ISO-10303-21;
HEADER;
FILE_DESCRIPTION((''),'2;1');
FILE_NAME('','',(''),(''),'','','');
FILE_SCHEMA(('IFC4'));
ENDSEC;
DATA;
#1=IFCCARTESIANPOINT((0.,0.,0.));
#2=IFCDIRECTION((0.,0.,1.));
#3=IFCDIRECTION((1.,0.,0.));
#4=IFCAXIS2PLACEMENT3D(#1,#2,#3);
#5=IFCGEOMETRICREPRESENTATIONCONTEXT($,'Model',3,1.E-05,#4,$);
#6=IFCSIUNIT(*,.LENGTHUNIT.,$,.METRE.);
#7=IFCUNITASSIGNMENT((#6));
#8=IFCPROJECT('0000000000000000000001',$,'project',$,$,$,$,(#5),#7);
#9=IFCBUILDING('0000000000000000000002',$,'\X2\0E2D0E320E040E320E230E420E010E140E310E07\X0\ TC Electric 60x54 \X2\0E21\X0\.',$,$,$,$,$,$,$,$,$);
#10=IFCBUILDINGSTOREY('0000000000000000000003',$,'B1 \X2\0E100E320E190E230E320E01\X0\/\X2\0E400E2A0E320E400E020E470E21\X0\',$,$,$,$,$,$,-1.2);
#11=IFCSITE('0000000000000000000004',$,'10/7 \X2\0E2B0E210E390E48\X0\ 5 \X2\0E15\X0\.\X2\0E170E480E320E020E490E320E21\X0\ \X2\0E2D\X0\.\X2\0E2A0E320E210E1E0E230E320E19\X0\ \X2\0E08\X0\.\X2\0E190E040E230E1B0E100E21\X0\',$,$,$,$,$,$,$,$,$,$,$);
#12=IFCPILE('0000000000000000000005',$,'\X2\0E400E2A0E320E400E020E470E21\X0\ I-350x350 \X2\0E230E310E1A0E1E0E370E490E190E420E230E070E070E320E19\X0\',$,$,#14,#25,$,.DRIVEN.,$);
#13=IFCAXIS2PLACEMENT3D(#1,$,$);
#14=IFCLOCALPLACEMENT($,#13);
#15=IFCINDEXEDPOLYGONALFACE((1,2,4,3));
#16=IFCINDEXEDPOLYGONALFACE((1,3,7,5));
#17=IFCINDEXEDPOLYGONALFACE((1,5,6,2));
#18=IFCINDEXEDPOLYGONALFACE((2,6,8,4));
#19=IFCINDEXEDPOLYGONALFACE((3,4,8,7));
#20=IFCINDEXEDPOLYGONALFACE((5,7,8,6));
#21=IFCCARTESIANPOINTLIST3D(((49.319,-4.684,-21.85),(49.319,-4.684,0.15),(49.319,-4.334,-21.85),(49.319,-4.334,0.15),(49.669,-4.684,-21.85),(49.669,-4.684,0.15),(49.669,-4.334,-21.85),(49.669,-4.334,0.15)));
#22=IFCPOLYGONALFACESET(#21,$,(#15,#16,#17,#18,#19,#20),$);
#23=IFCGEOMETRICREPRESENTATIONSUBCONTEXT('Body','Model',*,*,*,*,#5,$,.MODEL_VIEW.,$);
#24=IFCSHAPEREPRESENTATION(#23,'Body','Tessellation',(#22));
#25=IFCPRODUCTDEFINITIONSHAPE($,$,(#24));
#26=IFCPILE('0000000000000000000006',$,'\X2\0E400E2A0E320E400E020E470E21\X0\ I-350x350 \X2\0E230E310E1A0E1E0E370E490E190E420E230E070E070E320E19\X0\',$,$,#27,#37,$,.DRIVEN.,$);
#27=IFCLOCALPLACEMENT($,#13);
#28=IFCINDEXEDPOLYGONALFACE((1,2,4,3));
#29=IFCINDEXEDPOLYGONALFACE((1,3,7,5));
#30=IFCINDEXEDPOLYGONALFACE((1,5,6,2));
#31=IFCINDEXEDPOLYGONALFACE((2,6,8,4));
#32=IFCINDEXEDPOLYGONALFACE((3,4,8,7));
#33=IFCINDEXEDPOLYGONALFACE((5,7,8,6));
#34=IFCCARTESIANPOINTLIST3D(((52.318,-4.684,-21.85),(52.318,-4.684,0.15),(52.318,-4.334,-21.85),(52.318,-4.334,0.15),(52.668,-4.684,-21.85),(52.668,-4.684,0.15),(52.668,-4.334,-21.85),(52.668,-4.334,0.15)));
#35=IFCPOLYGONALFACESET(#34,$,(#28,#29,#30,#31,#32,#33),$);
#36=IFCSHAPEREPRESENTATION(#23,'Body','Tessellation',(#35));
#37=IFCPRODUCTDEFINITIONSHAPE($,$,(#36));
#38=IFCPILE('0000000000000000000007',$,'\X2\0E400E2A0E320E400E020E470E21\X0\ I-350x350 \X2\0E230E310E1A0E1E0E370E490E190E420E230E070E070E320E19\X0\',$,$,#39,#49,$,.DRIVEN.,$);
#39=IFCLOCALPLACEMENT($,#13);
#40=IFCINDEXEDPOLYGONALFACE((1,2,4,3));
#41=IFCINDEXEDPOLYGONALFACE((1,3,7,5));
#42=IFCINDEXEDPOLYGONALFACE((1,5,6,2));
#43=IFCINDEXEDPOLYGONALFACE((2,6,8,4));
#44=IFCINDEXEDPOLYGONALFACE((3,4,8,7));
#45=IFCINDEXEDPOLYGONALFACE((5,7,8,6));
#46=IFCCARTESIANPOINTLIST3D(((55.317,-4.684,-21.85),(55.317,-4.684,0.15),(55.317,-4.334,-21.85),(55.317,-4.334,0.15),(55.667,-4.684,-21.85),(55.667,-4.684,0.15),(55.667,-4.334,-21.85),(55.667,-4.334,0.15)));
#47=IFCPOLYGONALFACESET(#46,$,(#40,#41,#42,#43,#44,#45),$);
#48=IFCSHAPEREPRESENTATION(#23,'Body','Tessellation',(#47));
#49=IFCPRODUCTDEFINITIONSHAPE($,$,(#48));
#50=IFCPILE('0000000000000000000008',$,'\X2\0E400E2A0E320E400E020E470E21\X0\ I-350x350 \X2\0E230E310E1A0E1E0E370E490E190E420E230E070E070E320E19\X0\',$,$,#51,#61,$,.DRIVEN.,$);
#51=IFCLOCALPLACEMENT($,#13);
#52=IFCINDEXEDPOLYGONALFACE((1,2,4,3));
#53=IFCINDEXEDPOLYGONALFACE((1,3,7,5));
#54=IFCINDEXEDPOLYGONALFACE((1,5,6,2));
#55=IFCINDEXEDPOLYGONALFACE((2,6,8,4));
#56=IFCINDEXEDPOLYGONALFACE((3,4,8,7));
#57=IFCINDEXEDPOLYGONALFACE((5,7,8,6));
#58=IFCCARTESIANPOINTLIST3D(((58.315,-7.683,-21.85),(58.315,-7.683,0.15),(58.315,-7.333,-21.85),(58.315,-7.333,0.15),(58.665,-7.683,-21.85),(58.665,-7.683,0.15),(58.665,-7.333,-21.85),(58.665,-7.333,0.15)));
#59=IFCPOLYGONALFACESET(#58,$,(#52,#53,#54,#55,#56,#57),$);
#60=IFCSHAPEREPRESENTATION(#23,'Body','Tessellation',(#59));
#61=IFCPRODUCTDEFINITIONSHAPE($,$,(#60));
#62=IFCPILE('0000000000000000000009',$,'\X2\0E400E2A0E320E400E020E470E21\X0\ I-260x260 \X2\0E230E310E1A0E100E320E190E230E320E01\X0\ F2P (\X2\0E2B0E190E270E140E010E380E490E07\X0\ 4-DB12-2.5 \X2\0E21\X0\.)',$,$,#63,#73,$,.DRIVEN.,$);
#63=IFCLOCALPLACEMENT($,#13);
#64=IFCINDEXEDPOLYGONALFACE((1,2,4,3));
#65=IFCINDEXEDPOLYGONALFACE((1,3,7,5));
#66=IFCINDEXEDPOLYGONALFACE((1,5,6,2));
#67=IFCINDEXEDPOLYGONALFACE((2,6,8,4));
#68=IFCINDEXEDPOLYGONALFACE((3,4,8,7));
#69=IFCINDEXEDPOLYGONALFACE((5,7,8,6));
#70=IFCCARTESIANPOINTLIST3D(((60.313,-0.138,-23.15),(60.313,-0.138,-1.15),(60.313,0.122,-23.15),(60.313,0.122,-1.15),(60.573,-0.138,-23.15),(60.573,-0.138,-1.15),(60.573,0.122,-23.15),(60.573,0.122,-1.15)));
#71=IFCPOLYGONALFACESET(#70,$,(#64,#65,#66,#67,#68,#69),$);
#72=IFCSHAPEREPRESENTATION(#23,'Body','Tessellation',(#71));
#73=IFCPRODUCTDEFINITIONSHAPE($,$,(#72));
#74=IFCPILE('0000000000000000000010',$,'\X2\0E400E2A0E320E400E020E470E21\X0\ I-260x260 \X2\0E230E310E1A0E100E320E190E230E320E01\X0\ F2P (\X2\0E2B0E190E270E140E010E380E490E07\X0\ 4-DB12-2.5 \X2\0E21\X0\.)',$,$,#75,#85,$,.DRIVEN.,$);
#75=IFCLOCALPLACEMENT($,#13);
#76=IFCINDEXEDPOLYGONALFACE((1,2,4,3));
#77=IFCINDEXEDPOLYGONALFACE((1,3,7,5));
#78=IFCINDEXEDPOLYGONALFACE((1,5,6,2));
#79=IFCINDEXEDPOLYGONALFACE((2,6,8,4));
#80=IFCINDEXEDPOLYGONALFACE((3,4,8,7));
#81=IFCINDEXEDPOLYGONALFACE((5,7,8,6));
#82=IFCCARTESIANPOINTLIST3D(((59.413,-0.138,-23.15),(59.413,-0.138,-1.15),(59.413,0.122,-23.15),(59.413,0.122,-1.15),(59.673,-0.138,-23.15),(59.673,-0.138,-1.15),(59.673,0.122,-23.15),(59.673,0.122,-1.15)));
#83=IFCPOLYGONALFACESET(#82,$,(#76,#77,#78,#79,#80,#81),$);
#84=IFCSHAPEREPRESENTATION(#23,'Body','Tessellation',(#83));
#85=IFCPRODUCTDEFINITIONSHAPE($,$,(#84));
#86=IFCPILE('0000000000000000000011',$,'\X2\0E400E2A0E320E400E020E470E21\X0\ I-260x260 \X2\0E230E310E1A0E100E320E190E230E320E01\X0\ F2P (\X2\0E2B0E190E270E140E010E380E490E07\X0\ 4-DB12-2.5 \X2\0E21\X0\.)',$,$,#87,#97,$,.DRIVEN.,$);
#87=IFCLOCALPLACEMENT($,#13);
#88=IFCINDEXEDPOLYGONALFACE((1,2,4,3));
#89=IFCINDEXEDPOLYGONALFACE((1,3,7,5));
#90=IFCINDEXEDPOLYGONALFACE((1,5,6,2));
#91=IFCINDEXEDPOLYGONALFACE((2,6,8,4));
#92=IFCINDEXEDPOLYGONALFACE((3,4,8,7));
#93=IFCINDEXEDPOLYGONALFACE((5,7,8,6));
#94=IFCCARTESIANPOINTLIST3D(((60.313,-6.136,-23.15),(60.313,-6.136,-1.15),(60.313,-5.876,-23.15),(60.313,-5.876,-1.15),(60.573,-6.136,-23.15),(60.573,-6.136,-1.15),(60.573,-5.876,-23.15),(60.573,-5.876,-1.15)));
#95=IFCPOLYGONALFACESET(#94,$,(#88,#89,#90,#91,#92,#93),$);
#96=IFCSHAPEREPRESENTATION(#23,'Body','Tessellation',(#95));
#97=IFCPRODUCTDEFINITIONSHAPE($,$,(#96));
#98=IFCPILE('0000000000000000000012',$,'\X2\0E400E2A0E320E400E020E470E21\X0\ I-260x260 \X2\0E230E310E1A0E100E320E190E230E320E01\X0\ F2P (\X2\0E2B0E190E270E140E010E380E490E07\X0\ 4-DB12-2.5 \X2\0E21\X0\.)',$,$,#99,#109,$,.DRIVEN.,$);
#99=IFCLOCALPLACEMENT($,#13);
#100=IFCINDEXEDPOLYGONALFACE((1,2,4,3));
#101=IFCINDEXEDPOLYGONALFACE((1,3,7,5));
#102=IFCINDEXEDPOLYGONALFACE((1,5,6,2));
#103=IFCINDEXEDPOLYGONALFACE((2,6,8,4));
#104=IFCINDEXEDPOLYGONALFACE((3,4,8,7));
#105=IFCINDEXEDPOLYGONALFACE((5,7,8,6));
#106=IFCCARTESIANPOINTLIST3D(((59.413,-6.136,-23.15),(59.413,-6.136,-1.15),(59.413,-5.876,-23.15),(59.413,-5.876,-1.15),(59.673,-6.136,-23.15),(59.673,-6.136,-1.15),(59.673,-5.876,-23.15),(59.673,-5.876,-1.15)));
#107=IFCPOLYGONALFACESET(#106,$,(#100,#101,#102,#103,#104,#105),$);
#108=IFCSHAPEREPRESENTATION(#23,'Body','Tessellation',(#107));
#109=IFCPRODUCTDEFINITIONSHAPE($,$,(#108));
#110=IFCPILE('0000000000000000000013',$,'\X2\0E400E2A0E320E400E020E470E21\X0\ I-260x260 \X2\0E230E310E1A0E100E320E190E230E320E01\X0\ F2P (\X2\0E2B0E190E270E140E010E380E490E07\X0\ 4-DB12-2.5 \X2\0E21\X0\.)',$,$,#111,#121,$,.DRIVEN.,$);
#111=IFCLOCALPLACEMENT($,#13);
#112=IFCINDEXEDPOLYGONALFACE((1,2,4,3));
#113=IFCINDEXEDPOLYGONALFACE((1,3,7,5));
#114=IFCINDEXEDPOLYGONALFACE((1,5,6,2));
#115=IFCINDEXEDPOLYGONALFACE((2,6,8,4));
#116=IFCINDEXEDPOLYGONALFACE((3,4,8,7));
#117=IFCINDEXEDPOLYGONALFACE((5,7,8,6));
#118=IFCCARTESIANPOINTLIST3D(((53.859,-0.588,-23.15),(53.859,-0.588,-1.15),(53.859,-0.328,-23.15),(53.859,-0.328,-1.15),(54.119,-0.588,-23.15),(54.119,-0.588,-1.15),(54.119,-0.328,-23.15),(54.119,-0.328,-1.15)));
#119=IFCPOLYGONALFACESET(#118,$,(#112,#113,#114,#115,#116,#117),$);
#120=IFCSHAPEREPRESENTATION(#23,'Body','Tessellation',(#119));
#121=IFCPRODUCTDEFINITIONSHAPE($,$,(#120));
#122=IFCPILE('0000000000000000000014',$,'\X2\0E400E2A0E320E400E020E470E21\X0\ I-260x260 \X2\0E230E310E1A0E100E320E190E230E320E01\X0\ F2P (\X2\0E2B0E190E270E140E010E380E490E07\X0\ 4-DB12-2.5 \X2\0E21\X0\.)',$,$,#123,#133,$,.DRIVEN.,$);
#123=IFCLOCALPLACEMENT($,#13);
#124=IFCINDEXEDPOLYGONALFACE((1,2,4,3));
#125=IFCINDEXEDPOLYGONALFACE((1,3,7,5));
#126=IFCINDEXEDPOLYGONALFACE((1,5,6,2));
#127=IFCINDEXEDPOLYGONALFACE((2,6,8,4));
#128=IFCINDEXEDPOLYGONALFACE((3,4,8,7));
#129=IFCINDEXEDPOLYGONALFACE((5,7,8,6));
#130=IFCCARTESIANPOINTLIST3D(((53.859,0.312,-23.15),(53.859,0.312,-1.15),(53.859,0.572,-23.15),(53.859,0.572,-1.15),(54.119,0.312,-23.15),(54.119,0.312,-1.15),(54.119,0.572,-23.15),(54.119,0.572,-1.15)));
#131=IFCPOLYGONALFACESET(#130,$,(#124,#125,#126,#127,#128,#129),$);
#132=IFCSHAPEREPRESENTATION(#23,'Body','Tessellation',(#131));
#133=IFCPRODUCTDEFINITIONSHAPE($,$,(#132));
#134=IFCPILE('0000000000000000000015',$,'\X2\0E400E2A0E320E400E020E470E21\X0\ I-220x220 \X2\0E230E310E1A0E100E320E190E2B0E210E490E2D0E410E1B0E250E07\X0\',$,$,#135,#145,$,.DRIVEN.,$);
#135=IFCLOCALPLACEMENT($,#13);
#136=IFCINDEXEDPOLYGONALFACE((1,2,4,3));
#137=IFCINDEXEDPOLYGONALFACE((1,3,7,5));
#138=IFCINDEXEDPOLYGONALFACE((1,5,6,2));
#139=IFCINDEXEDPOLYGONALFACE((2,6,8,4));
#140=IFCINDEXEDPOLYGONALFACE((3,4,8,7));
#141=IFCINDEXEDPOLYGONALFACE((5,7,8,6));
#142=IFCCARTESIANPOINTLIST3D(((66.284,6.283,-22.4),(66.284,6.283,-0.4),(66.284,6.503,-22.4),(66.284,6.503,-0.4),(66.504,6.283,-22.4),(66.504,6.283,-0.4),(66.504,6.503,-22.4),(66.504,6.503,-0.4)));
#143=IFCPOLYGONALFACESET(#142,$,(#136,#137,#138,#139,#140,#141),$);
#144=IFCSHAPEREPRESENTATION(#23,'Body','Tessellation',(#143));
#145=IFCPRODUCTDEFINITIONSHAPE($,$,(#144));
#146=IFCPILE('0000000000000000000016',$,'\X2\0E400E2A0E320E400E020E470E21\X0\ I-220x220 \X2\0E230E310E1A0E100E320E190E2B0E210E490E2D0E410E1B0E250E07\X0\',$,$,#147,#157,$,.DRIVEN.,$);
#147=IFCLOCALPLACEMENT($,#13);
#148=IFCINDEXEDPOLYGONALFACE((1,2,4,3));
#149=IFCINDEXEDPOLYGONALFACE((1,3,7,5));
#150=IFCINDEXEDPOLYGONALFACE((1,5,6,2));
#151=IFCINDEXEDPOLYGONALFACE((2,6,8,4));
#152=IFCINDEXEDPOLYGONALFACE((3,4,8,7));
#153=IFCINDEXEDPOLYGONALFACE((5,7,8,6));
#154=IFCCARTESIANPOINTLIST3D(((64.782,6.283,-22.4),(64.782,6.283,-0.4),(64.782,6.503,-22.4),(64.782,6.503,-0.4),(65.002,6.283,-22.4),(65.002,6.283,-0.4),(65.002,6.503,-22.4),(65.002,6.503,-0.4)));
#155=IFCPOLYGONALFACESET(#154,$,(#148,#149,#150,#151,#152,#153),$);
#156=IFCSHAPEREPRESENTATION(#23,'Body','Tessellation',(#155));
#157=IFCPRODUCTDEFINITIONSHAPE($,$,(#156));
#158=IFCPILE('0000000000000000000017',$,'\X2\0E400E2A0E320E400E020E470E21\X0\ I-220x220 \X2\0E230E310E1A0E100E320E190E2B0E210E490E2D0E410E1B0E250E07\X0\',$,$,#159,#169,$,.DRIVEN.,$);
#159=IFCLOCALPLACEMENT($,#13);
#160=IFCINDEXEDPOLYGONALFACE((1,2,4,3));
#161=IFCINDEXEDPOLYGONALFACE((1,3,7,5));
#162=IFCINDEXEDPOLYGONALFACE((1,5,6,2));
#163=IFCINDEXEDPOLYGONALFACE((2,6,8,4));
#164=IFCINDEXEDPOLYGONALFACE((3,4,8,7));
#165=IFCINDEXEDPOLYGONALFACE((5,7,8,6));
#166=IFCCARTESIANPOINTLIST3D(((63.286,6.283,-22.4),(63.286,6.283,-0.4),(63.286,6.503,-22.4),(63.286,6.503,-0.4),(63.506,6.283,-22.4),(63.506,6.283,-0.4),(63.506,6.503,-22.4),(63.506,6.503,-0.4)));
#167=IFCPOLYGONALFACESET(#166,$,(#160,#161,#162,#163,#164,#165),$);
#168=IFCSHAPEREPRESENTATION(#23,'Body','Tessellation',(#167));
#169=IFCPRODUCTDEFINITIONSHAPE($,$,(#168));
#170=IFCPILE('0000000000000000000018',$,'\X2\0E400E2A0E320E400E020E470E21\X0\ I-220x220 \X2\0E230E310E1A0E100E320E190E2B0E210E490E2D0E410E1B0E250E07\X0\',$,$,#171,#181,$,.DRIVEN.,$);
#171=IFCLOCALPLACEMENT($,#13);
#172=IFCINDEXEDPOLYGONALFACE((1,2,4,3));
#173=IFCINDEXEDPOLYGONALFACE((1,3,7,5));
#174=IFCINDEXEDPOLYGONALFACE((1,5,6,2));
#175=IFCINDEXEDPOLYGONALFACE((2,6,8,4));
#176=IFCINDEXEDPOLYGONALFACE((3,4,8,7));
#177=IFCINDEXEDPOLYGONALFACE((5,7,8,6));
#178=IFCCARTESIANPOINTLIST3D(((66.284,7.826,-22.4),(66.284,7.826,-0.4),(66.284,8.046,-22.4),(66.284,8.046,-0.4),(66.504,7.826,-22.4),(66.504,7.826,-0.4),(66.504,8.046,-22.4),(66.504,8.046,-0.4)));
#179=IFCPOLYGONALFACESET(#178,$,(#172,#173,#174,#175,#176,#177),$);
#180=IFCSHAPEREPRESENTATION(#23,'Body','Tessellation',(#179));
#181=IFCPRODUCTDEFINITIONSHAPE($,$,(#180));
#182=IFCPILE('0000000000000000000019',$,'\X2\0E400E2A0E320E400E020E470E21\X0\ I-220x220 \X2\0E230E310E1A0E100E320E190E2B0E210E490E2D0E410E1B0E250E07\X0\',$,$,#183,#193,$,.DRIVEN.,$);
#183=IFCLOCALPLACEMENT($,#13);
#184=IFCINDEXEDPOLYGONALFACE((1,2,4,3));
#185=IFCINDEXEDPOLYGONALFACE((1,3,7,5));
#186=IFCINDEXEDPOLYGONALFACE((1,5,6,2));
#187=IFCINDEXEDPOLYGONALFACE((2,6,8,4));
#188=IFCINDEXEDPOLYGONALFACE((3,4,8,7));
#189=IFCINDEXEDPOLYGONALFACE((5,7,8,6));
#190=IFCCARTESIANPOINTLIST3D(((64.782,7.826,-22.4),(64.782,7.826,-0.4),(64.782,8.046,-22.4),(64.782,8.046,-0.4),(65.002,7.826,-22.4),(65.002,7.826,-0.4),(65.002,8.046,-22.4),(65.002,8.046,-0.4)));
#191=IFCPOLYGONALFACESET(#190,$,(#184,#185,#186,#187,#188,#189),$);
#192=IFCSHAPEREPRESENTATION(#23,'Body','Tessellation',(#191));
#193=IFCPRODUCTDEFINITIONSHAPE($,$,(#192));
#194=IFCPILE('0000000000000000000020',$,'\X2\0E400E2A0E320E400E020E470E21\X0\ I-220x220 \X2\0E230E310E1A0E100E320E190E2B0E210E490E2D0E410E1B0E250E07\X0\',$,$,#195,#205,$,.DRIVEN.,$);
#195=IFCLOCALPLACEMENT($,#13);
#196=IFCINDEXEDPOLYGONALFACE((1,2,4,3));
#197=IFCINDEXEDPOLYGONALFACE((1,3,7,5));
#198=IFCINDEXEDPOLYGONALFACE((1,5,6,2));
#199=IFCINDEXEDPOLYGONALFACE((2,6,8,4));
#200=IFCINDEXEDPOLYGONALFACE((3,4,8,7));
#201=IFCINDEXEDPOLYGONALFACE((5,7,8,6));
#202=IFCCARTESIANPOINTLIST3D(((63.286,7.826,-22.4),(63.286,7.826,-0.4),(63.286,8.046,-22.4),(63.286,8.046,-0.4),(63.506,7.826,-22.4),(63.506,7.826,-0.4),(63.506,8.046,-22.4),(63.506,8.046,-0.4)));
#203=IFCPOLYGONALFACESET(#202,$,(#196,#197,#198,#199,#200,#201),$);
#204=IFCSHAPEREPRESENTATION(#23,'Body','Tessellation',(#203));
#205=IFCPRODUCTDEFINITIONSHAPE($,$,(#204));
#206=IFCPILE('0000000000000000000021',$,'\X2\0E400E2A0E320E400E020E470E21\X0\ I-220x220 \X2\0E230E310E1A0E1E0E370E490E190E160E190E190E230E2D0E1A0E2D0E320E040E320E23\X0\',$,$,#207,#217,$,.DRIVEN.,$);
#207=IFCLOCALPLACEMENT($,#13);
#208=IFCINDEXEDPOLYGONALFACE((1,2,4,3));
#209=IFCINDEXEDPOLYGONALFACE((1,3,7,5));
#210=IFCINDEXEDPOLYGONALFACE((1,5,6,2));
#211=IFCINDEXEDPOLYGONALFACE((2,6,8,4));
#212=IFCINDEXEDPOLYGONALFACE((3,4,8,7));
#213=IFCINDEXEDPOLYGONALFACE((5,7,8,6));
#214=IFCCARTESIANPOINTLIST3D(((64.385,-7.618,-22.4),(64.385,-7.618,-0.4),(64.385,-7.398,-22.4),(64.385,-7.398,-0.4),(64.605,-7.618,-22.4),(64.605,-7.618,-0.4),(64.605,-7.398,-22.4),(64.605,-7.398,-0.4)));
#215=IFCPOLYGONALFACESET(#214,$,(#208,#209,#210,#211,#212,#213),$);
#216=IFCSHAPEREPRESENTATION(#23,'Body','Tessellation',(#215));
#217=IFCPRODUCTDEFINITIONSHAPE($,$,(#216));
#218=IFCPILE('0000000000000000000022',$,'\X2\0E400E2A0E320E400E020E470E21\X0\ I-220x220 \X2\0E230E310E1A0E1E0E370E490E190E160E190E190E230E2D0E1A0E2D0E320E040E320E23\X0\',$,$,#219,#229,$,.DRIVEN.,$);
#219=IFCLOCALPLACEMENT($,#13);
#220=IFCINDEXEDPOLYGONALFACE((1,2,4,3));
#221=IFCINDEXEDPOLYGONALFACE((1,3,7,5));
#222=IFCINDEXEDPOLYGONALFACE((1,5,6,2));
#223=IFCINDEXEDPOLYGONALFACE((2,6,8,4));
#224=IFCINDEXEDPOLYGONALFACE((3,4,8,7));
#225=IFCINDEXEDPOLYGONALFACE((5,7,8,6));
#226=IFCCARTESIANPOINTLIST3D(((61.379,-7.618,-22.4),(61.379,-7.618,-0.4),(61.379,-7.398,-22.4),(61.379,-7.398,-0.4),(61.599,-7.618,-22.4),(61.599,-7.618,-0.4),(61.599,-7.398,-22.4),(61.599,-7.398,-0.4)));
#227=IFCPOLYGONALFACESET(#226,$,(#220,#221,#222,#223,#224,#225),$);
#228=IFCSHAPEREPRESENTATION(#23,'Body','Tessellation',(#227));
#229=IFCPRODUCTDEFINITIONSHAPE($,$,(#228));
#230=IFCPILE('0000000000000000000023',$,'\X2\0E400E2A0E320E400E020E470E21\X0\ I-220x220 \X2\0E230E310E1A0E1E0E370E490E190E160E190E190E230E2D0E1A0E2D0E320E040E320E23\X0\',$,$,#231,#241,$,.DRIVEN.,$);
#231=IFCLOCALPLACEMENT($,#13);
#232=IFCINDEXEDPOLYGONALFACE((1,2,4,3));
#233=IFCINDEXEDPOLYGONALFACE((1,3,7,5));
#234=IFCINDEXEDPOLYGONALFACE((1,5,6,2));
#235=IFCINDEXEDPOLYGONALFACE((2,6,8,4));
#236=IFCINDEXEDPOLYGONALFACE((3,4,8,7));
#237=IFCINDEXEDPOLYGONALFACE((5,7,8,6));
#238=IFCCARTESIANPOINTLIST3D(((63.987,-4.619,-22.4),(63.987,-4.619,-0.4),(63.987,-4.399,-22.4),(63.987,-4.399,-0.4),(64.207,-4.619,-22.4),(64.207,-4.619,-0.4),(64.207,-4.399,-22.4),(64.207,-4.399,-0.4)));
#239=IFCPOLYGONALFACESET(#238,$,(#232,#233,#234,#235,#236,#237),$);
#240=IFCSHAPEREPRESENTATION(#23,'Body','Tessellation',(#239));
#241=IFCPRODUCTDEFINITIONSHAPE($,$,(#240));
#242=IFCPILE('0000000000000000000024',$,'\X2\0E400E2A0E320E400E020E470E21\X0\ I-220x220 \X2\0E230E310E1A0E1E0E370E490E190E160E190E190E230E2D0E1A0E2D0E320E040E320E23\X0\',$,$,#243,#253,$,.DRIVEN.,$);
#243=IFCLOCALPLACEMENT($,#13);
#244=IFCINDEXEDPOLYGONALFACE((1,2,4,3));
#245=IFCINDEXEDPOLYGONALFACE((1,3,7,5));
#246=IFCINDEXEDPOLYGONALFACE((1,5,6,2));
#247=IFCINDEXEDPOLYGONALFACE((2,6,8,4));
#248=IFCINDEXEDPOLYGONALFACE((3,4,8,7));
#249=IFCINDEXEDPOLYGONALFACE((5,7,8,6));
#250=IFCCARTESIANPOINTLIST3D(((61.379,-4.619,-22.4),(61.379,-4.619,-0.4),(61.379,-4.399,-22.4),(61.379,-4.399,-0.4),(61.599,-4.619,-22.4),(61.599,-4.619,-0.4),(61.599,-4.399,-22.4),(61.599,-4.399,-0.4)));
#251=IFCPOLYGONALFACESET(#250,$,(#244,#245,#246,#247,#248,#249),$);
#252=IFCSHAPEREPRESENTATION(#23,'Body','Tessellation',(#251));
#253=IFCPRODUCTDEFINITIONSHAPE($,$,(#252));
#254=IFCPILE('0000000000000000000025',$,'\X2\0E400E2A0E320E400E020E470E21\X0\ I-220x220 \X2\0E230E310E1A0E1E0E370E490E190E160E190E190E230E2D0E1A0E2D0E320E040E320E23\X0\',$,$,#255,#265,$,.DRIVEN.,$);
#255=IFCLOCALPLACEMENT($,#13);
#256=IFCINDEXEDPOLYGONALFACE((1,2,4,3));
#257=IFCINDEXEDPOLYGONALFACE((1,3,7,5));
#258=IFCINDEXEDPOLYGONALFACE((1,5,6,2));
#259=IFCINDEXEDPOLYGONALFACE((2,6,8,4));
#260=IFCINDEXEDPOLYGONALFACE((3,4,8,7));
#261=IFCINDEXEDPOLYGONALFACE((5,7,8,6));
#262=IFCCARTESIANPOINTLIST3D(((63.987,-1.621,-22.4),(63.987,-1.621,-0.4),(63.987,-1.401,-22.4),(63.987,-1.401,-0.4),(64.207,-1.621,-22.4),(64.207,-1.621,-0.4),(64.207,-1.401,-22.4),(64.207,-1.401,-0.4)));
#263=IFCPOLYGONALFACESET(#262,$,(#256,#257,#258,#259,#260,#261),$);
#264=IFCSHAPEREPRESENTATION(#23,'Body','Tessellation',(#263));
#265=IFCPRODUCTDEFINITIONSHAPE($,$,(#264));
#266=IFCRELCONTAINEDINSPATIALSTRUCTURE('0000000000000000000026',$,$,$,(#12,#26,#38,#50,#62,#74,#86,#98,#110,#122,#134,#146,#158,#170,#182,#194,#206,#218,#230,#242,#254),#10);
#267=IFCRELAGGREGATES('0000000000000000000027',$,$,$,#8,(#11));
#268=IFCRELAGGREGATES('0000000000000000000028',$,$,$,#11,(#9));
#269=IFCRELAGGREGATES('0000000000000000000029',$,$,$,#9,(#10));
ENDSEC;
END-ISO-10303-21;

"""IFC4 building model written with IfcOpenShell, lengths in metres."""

from ifc_helpers import new_model, si_unit, frame, origin, origin_with_axes, origin_2d, place, context, subcontext, project, spatial, rectangle, extrude, element, save


model = new_model("IFC4")

# Units and contexts
model_context = context("Model", 3, precision=1e-05, world=origin_with_axes())
body_context = subcontext(model_context, "Body", "Model", "MODEL_VIEW")
ifc_project = project(units=[si_unit("LENGTHUNIT", "METRE")], contexts=[model_context])

# Site, building, storey
site = spatial("IfcSite", under=ifc_project, Name="10/7 หมู่ 5 ต.ท่าข้าม อ.สามพราน จ.นครปฐม")
building = spatial("IfcBuilding", under=site, Name="อาคารโกดัง TC Electric 60x54 ม.")
storey = spatial("IfcBuildingStorey", under=building, Name="B1 ฐานราก/เสาเข็ม", Elevation=-1.2)

# Piles
for number, where, z_axis, x_axis, name in (
    (1, (49.494, -4.509, -21.85), (0.0, 0.0, 1.0), (1.0, 0.0, 0.0), "เสาเข็ม I-350x350 รับพื้นโรงงาน"),
    (2, (52.493, -4.509, -21.85), (0.0, 0.0, 1.0), (1.0, 0.0, 0.0), "เสาเข็ม I-350x350 รับพื้นโรงงาน"),
    (3, (55.492, -4.509, -21.85), (0.0, 0.0, 1.0), (1.0, 0.0, 0.0), "เสาเข็ม I-350x350 รับพื้นโรงงาน"),
    (4, (58.49, -7.508, -21.85), (0.0, 0.0, 1.0), (1.0, 0.0, 0.0), "เสาเข็ม I-350x350 รับพื้นโรงงาน"),
):
    element("IfcPile", number, at=place(None, frame(where, z_axis=z_axis, x_axis=x_axis)), inside=storey, Name=name, PredefinedType="DRIVEN", context=body_context, shape_type="SweptSolid", body=[
        extrude(rectangle(XDim=0.35, YDim=0.35, at=origin_2d()), origin(), (0.0, 0.0, 1.0), 22.0),
    ])
for number, where, z_axis, x_axis, name in (
    (5, (60.443, -0.008, -23.15), (0.0, 0.0, 1.0), (1.0, 0.0, 0.0), "เสาเข็ม I-260x260 รับฐานราก F2P (หนวดกุ้ง 4-DB12-2.5 ม.)"),
    (6, (59.543, -0.008, -23.15), (0.0, 0.0, 1.0), (1.0, 0.0, 0.0), "เสาเข็ม I-260x260 รับฐานราก F2P (หนวดกุ้ง 4-DB12-2.5 ม.)"),
    (7, (60.443, -6.006, -23.15), (0.0, 0.0, 1.0), (1.0, 0.0, 0.0), "เสาเข็ม I-260x260 รับฐานราก F2P (หนวดกุ้ง 4-DB12-2.5 ม.)"),
    (8, (59.543, -6.006, -23.15), (0.0, 0.0, 1.0), (1.0, 0.0, 0.0), "เสาเข็ม I-260x260 รับฐานราก F2P (หนวดกุ้ง 4-DB12-2.5 ม.)"),
    (9, (53.989, -0.458, -23.15), (0.0, 0.0, 1.0), (1.0, 0.0, 0.0), "เสาเข็ม I-260x260 รับฐานราก F2P (หนวดกุ้ง 4-DB12-2.5 ม.)"),
    (10, (53.989, 0.442, -23.15), (0.0, 0.0, 1.0), (1.0, 0.0, 0.0), "เสาเข็ม I-260x260 รับฐานราก F2P (หนวดกุ้ง 4-DB12-2.5 ม.)"),
):
    element("IfcPile", number, at=place(None, frame(where, z_axis=z_axis, x_axis=x_axis)), inside=storey, Name=name, PredefinedType="DRIVEN", context=body_context, shape_type="SweptSolid", body=[
        extrude(rectangle(XDim=0.26, YDim=0.26, at=origin_2d()), origin(), (0.0, 0.0, 1.0), 22.0),
    ])
for number, where, z_axis, x_axis, name in (
    (11, (66.394, 6.393, -22.4), (0.0, 0.0, 1.0), (1.0, 0.0, 0.0), "เสาเข็ม I-220x220 รับฐานหม้อแปลง"),
    (12, (64.892, 6.393, -22.4), (0.0, 0.0, 1.0), (1.0, 0.0, 0.0), "เสาเข็ม I-220x220 รับฐานหม้อแปลง"),
    (13, (63.396, 6.393, -22.4), (0.0, 0.0, 1.0), (1.0, 0.0, 0.0), "เสาเข็ม I-220x220 รับฐานหม้อแปลง"),
    (14, (66.394, 7.936, -22.4), (0.0, 0.0, 1.0), (1.0, 0.0, 0.0), "เสาเข็ม I-220x220 รับฐานหม้อแปลง"),
    (15, (64.892, 7.936, -22.4), (0.0, 0.0, 1.0), (1.0, 0.0, 0.0), "เสาเข็ม I-220x220 รับฐานหม้อแปลง"),
    (16, (63.396, 7.936, -22.4), (0.0, 0.0, 1.0), (1.0, 0.0, 0.0), "เสาเข็ม I-220x220 รับฐานหม้อแปลง"),
    (17, (64.495, -7.508, -22.4), (0.0, 0.0, 1.0), (1.0, 0.0, 0.0), "เสาเข็ม I-220x220 รับพื้นถนนรอบอาคาร"),
    (18, (61.489, -7.508, -22.4), (0.0, 0.0, 1.0), (1.0, 0.0, 0.0), "เสาเข็ม I-220x220 รับพื้นถนนรอบอาคาร"),
    (19, (64.097, -4.509, -22.4), (0.0, 0.0, 1.0), (1.0, 0.0, 0.0), "เสาเข็ม I-220x220 รับพื้นถนนรอบอาคาร"),
    (20, (61.489, -4.509, -22.4), (0.0, 0.0, 1.0), (1.0, 0.0, 0.0), "เสาเข็ม I-220x220 รับพื้นถนนรอบอาคาร"),
    (21, (64.097, -1.511, -22.4), (0.0, 0.0, 1.0), (1.0, 0.0, 0.0), "เสาเข็ม I-220x220 รับพื้นถนนรอบอาคาร"),
):
    element("IfcPile", number, at=place(None, frame(where, z_axis=z_axis, x_axis=x_axis)), inside=storey, Name=name, PredefinedType="DRIVEN", context=body_context, shape_type="SweptSolid", body=[
        extrude(rectangle(XDim=0.22, YDim=0.22, at=origin_2d()), origin(), (0.0, 0.0, 1.0), 22.0),
    ])

save(model, "model.ifc")
